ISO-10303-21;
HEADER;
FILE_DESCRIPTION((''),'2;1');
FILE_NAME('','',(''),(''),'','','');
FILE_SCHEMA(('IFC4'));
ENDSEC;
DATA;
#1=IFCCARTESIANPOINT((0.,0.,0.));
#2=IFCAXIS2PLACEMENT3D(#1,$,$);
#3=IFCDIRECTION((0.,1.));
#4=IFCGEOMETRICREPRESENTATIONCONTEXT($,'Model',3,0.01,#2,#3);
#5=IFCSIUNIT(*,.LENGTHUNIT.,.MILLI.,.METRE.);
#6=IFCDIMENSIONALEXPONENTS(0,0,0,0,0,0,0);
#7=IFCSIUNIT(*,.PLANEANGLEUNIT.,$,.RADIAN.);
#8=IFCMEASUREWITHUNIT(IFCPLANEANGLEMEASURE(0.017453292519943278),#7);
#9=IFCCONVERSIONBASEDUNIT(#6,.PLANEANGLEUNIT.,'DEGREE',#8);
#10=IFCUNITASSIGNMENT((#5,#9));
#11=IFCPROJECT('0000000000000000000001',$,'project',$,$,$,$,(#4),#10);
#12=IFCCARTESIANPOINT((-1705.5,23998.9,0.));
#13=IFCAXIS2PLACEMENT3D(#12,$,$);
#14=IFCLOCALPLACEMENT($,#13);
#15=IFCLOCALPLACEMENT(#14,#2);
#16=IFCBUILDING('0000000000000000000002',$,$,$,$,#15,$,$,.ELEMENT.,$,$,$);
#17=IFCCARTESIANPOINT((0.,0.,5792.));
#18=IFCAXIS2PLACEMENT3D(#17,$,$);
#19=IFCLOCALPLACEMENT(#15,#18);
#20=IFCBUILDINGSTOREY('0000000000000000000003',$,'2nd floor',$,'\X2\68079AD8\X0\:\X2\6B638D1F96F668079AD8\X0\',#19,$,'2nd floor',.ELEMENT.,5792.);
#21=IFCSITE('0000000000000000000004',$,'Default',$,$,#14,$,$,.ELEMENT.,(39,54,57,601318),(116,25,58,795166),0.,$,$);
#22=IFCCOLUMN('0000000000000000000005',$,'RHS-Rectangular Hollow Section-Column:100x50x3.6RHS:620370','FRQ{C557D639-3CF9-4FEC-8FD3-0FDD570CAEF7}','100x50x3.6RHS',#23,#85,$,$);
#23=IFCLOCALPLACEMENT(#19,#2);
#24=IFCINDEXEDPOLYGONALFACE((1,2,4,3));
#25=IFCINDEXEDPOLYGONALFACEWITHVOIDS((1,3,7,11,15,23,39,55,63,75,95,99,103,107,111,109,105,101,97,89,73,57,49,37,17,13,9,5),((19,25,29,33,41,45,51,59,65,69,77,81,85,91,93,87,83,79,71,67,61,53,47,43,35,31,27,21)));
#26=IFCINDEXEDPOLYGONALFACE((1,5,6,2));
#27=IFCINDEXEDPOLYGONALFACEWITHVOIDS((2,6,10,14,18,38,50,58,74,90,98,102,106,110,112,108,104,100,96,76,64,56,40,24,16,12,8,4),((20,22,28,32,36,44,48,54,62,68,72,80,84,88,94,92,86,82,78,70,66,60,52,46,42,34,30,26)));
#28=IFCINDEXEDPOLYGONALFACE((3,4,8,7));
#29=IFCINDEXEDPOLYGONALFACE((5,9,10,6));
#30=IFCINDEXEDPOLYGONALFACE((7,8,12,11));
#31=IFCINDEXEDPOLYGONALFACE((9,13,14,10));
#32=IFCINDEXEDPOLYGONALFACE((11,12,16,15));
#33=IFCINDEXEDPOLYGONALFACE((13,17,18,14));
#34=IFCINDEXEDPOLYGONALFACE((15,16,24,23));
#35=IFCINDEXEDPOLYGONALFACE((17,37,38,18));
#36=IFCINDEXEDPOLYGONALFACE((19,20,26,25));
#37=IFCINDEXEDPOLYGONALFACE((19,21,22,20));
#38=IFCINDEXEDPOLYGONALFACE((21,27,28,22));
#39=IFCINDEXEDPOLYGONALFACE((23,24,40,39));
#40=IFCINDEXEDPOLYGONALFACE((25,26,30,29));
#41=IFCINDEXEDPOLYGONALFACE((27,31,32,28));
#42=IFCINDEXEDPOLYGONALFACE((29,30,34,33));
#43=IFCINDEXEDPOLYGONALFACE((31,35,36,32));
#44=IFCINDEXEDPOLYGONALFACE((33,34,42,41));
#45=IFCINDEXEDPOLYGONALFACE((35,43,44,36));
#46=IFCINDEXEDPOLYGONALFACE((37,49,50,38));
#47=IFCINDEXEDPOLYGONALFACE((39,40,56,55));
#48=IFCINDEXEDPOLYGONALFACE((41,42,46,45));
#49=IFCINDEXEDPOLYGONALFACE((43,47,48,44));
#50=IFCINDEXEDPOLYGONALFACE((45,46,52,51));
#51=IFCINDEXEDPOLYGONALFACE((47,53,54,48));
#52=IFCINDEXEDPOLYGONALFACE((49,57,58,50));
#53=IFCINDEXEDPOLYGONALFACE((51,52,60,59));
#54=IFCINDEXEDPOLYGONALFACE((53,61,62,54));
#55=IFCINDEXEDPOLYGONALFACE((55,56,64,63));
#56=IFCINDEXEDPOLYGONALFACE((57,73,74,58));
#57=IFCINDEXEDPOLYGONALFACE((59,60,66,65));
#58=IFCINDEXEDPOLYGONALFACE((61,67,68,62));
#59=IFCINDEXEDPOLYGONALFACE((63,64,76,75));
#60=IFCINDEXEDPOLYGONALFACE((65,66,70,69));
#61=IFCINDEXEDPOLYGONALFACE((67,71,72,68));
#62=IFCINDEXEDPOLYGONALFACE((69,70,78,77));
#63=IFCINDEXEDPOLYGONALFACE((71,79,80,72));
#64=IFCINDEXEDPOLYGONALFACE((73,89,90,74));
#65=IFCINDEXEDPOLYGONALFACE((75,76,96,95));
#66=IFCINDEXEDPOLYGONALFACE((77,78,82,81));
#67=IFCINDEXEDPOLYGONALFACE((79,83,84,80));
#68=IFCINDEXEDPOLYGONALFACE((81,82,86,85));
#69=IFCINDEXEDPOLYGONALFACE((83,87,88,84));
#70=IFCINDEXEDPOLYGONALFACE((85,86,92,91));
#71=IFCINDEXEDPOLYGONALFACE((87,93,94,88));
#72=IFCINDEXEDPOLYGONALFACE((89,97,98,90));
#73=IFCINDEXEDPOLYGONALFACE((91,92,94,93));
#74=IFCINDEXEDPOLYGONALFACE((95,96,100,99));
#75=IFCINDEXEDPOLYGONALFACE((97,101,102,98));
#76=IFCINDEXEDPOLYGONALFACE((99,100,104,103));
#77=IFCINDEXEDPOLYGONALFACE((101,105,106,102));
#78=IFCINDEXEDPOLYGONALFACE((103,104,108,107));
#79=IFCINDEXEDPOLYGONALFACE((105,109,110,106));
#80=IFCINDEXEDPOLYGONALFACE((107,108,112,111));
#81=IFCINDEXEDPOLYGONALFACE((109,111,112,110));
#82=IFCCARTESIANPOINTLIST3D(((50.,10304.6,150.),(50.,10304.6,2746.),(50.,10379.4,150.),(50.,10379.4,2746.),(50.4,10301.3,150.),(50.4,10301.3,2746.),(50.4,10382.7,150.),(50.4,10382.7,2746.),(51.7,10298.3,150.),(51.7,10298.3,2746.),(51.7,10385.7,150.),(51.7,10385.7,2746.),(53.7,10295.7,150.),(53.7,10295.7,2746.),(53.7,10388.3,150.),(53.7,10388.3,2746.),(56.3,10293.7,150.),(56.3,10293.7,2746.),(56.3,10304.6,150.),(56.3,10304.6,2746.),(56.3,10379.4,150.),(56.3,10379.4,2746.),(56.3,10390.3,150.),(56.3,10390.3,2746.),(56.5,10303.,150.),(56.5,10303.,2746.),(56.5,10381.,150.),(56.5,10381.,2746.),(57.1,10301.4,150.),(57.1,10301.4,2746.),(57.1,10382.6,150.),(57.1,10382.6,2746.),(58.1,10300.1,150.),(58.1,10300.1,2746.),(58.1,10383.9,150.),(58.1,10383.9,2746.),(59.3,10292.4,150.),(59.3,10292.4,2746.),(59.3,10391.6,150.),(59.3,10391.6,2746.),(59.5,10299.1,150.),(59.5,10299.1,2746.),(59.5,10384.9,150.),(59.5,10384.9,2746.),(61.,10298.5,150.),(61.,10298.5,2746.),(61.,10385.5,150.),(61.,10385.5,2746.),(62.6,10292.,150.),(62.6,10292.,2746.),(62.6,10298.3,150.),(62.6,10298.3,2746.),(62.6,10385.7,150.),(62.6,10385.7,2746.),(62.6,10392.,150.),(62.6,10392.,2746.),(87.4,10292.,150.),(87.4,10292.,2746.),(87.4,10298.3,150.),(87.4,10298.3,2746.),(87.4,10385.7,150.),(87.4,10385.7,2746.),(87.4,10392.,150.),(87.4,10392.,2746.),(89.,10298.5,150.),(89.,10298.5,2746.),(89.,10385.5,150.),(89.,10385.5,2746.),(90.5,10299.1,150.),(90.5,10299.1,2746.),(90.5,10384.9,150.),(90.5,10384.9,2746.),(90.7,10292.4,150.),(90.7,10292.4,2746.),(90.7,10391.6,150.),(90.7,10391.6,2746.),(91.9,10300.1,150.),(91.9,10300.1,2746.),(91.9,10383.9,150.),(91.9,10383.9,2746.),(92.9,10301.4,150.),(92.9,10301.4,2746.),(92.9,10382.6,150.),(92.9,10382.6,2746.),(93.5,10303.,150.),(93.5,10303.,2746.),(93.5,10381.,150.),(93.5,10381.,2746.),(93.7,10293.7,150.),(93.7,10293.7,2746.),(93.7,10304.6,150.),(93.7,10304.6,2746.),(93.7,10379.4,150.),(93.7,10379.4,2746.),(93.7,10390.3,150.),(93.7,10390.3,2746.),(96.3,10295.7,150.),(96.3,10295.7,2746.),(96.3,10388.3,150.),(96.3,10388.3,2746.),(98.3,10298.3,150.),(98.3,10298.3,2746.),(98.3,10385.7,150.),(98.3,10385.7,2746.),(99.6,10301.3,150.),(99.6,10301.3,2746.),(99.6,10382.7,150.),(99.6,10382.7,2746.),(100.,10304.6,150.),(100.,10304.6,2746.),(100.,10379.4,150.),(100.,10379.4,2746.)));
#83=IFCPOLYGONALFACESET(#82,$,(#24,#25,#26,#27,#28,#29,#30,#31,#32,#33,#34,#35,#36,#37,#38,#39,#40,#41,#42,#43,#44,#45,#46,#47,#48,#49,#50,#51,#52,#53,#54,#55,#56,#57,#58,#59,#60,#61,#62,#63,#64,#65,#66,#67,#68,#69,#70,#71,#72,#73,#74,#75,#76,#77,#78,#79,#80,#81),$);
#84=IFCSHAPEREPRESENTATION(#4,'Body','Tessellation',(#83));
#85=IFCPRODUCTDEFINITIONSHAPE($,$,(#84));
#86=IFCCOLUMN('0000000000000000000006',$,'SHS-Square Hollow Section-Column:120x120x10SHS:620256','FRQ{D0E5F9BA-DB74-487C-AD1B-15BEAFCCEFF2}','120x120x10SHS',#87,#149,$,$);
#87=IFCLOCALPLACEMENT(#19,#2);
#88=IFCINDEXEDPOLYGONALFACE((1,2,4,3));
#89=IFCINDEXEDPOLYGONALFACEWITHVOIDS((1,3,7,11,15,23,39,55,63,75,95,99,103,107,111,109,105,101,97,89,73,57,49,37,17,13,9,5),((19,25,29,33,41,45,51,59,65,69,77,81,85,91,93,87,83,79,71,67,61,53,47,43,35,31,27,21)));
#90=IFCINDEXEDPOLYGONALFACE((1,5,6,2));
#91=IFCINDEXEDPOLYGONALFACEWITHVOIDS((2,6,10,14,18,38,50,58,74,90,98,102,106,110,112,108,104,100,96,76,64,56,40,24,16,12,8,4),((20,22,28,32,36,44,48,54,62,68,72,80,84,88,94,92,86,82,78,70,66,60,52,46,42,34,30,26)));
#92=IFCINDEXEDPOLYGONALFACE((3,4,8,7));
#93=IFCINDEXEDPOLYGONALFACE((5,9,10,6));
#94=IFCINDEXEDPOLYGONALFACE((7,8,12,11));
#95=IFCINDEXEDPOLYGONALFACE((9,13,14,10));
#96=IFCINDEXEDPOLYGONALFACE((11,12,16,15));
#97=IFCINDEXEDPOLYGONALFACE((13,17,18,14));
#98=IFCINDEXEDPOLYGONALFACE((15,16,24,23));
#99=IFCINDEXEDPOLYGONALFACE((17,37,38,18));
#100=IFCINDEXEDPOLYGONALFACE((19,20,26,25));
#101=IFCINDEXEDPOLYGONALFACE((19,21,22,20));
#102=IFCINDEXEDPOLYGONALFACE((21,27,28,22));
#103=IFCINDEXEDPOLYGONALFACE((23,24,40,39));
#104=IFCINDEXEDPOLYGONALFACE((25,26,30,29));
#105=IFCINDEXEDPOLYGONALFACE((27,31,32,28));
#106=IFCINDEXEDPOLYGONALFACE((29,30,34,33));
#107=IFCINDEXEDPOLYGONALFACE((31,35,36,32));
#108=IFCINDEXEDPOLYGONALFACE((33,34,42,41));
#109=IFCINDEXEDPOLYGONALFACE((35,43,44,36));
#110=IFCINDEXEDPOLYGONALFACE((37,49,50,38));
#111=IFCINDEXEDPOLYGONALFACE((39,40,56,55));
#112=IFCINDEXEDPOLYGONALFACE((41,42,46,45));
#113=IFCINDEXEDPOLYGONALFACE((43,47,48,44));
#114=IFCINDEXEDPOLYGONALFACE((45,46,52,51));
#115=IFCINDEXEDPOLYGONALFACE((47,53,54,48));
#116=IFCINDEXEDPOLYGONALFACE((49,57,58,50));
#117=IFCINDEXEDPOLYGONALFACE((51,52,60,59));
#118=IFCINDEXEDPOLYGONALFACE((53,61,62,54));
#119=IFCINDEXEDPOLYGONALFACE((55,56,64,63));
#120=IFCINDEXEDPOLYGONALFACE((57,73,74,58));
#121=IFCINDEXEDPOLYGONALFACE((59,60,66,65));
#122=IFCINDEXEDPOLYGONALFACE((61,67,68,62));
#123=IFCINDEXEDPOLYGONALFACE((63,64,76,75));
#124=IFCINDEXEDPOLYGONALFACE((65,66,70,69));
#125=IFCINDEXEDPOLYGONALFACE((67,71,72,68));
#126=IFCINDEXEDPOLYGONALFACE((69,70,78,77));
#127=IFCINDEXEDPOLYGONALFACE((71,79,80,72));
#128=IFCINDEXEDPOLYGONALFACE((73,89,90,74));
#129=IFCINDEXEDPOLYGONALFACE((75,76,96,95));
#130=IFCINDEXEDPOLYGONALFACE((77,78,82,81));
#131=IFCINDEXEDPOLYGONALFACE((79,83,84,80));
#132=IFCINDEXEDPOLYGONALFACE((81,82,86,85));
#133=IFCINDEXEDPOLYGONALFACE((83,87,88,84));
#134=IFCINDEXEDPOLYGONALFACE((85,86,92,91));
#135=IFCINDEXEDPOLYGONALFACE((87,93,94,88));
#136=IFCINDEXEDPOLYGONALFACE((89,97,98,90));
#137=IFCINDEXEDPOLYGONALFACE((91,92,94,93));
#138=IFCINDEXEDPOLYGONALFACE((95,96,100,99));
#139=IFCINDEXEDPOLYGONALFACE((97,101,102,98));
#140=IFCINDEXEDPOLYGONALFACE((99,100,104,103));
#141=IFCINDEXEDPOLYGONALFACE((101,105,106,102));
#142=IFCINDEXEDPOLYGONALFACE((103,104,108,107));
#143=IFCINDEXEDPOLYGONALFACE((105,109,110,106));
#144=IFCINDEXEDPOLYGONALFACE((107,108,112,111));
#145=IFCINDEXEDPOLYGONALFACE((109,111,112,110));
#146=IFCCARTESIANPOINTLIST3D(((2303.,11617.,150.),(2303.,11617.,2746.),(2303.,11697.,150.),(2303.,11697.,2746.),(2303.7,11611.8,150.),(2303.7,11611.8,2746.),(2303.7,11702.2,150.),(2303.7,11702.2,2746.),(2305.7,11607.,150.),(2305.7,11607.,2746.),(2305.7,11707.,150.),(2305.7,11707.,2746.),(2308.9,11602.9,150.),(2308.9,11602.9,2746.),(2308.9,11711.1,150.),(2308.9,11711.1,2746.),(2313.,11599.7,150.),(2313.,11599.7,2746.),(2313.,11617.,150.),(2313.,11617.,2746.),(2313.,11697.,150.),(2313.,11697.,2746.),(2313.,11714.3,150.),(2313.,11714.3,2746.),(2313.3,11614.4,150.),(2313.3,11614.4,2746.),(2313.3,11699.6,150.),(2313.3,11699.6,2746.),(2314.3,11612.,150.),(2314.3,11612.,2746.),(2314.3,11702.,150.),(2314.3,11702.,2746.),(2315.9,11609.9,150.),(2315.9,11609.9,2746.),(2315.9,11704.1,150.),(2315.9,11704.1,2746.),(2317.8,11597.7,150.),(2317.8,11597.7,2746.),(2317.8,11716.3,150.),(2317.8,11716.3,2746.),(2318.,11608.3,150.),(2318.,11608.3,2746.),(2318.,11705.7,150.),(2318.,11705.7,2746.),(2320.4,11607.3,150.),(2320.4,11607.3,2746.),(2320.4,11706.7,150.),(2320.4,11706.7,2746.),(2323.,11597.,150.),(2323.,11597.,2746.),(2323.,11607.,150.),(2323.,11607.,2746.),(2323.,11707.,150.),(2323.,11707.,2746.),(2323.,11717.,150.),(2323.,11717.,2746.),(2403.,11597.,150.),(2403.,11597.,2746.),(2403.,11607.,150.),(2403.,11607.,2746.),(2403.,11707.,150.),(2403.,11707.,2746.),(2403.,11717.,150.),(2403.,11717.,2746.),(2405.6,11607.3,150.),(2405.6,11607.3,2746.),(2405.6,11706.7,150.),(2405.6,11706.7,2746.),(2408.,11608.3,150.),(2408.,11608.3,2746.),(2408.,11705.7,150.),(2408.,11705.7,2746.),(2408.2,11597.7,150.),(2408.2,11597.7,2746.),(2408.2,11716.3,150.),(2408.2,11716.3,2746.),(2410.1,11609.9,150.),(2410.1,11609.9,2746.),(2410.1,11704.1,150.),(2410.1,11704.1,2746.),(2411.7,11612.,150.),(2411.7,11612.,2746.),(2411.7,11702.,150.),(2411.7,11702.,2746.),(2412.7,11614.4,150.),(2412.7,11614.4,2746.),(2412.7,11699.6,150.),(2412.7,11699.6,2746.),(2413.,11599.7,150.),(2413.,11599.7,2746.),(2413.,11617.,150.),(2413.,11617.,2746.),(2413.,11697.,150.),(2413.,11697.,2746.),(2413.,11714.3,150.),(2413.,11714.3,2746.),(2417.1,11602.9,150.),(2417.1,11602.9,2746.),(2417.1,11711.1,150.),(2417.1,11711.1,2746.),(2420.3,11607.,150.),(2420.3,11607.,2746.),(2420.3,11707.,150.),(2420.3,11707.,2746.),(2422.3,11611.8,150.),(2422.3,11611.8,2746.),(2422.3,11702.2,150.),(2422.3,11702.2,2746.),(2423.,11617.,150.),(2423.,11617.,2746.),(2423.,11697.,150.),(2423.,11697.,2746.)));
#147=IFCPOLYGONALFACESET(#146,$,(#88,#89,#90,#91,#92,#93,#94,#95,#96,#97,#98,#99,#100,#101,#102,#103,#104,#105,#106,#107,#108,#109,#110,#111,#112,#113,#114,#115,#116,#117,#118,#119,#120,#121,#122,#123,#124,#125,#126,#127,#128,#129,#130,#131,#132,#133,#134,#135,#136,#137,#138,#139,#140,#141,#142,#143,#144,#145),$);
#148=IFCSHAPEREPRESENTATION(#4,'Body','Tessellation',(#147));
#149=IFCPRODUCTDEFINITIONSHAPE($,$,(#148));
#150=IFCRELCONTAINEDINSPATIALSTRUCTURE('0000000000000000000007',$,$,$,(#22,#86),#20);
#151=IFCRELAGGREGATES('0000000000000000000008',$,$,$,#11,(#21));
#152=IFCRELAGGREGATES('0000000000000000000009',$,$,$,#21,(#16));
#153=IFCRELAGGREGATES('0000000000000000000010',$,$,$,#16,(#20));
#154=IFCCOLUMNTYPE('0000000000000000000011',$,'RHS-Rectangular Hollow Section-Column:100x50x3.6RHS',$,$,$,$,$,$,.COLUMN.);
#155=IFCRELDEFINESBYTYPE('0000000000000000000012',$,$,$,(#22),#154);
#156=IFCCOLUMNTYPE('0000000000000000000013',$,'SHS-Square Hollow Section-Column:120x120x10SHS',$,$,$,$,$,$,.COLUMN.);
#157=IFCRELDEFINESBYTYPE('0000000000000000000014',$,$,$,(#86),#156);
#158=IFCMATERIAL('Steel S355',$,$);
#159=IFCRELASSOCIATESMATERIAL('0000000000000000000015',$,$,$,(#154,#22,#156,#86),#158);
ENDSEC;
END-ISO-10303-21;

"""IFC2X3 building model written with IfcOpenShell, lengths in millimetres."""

from ifc_helpers import new_model, entity, si_unit, converted_unit, direction, frame, origin, origin_2d, place, context, project, spatial, hollow_rectangle, extrude, clip, halfspace, material, type_object, element, save


model = new_model("IFC2X3")

# Units and contexts
model_context = context("Model", 3, precision=0.01, world=origin(), true_north=direction((0.0, 1.0)))
ifc_project = project(units=[si_unit("LENGTHUNIT", "METRE", prefix="MILLI"), converted_unit("PLANEANGLEUNIT", "DEGREE", entity("IfcPlaneAngleMeasure", 0.017453292519943278), si_unit("PLANEANGLEUNIT", "RADIAN"), dimensions=[0, 0, 0, 0, 0, 0, 0])], contexts=[model_context])

# Site, building, storey
site_placement = place(None, frame((-1705.5, 23998.9, 0.0)))
site = spatial("IfcSite", under=ifc_project, at=site_placement, Name="Default", CompositionType="ELEMENT", RefLatitude=(39, 54, 57, 601318), RefLongitude=(116, 25, 58, 795166), RefElevation=0.0)
building_placement = place(site_placement, origin())
building = spatial("IfcBuilding", under=site, at=building_placement, CompositionType="ELEMENT")
storey_placement = place(building_placement, frame((0.0, 0.0, 5792.0)))
storey = spatial("IfcBuildingStorey", under=building, at=storey_placement, Name="2nd floor", ObjectType="标高:正负零标高", LongName="2nd floor", CompositionType="ELEMENT", Elevation=5792.0)

# Shared definitions
ifc_material_1 = material(Name="Steel S355")

# Columns
column_type_1 = type_object("IfcColumnType", Name="RHS-Rectangular Hollow Section-Column:100x50x3.6RHS", PredefinedType="COLUMN", material=ifc_material_1)
column_1_placement = place(storey_placement, frame((75.0, 10342.0, 2746.0), z_axis=(0.0, 0.0, 1.0), x_axis=(-1.0, 0.0, 0.0)))
element("IfcColumn", 1, at=column_1_placement, inside=storey, type_object=column_type_1, material=ifc_material_1, Name="RHS-Rectangular Hollow Section-Column:100x50x3.6RHS:620370", Description="FRQ{C557D639-3CF9-4FEC-8FD3-0FDD570CAEF7}", ObjectType="100x50x3.6RHS", context=model_context, shape_type="Clipping", body=[
    clip(extrude(hollow_rectangle(XDim=50.0, YDim=100.0, WallThickness=6.3, InnerFilletRadius=6.3, OuterFilletRadius=12.6, at=origin_2d()), origin(), (0.0, 0.0, -1.0), 2651.9), halfspace(frame((75.0, 10342.0, -2596.0), z_axis=(0.0, 0.0, 1.0), x_axis=(-1.0, 0.0, 0.0)), True)),
])
column_type_2 = type_object("IfcColumnType", Name="SHS-Square Hollow Section-Column:120x120x10SHS", PredefinedType="COLUMN", material=ifc_material_1)
column_2_placement = place(storey_placement, frame((2363.0, 11657.0, 2830.9), z_axis=(0.0, 0.0, 1.0), x_axis=(0.0, -1.0, 0.0)))
element("IfcColumn", 2, at=column_2_placement, inside=storey, type_object=column_type_2, material=ifc_material_1, Name="SHS-Square Hollow Section-Column:120x120x10SHS:620256", Description="FRQ{D0E5F9BA-DB74-487C-AD1B-15BEAFCCEFF2}", ObjectType="120x120x10SHS", context=model_context, shape_type="Clipping", body=[
    clip(clip(extrude(hollow_rectangle(XDim=120.0, YDim=120.0, WallThickness=10.0, InnerFilletRadius=10.0, OuterFilletRadius=20.0, at=origin_2d()), origin(), (0.0, 0.0, -1.0), 2765.7), halfspace(frame((11657.0, -2363.0, -2680.9), z_axis=(0.0, 0.0, 1.0), x_axis=(0.0, 1.0, 0.0)), True)), halfspace(frame((11657.0, -2363.0, -84.9), z_axis=(0.0, 0.0, -1.0), x_axis=(0.0, -1.0, 0.0)), True)),
])

save(model, "model.ifc")
